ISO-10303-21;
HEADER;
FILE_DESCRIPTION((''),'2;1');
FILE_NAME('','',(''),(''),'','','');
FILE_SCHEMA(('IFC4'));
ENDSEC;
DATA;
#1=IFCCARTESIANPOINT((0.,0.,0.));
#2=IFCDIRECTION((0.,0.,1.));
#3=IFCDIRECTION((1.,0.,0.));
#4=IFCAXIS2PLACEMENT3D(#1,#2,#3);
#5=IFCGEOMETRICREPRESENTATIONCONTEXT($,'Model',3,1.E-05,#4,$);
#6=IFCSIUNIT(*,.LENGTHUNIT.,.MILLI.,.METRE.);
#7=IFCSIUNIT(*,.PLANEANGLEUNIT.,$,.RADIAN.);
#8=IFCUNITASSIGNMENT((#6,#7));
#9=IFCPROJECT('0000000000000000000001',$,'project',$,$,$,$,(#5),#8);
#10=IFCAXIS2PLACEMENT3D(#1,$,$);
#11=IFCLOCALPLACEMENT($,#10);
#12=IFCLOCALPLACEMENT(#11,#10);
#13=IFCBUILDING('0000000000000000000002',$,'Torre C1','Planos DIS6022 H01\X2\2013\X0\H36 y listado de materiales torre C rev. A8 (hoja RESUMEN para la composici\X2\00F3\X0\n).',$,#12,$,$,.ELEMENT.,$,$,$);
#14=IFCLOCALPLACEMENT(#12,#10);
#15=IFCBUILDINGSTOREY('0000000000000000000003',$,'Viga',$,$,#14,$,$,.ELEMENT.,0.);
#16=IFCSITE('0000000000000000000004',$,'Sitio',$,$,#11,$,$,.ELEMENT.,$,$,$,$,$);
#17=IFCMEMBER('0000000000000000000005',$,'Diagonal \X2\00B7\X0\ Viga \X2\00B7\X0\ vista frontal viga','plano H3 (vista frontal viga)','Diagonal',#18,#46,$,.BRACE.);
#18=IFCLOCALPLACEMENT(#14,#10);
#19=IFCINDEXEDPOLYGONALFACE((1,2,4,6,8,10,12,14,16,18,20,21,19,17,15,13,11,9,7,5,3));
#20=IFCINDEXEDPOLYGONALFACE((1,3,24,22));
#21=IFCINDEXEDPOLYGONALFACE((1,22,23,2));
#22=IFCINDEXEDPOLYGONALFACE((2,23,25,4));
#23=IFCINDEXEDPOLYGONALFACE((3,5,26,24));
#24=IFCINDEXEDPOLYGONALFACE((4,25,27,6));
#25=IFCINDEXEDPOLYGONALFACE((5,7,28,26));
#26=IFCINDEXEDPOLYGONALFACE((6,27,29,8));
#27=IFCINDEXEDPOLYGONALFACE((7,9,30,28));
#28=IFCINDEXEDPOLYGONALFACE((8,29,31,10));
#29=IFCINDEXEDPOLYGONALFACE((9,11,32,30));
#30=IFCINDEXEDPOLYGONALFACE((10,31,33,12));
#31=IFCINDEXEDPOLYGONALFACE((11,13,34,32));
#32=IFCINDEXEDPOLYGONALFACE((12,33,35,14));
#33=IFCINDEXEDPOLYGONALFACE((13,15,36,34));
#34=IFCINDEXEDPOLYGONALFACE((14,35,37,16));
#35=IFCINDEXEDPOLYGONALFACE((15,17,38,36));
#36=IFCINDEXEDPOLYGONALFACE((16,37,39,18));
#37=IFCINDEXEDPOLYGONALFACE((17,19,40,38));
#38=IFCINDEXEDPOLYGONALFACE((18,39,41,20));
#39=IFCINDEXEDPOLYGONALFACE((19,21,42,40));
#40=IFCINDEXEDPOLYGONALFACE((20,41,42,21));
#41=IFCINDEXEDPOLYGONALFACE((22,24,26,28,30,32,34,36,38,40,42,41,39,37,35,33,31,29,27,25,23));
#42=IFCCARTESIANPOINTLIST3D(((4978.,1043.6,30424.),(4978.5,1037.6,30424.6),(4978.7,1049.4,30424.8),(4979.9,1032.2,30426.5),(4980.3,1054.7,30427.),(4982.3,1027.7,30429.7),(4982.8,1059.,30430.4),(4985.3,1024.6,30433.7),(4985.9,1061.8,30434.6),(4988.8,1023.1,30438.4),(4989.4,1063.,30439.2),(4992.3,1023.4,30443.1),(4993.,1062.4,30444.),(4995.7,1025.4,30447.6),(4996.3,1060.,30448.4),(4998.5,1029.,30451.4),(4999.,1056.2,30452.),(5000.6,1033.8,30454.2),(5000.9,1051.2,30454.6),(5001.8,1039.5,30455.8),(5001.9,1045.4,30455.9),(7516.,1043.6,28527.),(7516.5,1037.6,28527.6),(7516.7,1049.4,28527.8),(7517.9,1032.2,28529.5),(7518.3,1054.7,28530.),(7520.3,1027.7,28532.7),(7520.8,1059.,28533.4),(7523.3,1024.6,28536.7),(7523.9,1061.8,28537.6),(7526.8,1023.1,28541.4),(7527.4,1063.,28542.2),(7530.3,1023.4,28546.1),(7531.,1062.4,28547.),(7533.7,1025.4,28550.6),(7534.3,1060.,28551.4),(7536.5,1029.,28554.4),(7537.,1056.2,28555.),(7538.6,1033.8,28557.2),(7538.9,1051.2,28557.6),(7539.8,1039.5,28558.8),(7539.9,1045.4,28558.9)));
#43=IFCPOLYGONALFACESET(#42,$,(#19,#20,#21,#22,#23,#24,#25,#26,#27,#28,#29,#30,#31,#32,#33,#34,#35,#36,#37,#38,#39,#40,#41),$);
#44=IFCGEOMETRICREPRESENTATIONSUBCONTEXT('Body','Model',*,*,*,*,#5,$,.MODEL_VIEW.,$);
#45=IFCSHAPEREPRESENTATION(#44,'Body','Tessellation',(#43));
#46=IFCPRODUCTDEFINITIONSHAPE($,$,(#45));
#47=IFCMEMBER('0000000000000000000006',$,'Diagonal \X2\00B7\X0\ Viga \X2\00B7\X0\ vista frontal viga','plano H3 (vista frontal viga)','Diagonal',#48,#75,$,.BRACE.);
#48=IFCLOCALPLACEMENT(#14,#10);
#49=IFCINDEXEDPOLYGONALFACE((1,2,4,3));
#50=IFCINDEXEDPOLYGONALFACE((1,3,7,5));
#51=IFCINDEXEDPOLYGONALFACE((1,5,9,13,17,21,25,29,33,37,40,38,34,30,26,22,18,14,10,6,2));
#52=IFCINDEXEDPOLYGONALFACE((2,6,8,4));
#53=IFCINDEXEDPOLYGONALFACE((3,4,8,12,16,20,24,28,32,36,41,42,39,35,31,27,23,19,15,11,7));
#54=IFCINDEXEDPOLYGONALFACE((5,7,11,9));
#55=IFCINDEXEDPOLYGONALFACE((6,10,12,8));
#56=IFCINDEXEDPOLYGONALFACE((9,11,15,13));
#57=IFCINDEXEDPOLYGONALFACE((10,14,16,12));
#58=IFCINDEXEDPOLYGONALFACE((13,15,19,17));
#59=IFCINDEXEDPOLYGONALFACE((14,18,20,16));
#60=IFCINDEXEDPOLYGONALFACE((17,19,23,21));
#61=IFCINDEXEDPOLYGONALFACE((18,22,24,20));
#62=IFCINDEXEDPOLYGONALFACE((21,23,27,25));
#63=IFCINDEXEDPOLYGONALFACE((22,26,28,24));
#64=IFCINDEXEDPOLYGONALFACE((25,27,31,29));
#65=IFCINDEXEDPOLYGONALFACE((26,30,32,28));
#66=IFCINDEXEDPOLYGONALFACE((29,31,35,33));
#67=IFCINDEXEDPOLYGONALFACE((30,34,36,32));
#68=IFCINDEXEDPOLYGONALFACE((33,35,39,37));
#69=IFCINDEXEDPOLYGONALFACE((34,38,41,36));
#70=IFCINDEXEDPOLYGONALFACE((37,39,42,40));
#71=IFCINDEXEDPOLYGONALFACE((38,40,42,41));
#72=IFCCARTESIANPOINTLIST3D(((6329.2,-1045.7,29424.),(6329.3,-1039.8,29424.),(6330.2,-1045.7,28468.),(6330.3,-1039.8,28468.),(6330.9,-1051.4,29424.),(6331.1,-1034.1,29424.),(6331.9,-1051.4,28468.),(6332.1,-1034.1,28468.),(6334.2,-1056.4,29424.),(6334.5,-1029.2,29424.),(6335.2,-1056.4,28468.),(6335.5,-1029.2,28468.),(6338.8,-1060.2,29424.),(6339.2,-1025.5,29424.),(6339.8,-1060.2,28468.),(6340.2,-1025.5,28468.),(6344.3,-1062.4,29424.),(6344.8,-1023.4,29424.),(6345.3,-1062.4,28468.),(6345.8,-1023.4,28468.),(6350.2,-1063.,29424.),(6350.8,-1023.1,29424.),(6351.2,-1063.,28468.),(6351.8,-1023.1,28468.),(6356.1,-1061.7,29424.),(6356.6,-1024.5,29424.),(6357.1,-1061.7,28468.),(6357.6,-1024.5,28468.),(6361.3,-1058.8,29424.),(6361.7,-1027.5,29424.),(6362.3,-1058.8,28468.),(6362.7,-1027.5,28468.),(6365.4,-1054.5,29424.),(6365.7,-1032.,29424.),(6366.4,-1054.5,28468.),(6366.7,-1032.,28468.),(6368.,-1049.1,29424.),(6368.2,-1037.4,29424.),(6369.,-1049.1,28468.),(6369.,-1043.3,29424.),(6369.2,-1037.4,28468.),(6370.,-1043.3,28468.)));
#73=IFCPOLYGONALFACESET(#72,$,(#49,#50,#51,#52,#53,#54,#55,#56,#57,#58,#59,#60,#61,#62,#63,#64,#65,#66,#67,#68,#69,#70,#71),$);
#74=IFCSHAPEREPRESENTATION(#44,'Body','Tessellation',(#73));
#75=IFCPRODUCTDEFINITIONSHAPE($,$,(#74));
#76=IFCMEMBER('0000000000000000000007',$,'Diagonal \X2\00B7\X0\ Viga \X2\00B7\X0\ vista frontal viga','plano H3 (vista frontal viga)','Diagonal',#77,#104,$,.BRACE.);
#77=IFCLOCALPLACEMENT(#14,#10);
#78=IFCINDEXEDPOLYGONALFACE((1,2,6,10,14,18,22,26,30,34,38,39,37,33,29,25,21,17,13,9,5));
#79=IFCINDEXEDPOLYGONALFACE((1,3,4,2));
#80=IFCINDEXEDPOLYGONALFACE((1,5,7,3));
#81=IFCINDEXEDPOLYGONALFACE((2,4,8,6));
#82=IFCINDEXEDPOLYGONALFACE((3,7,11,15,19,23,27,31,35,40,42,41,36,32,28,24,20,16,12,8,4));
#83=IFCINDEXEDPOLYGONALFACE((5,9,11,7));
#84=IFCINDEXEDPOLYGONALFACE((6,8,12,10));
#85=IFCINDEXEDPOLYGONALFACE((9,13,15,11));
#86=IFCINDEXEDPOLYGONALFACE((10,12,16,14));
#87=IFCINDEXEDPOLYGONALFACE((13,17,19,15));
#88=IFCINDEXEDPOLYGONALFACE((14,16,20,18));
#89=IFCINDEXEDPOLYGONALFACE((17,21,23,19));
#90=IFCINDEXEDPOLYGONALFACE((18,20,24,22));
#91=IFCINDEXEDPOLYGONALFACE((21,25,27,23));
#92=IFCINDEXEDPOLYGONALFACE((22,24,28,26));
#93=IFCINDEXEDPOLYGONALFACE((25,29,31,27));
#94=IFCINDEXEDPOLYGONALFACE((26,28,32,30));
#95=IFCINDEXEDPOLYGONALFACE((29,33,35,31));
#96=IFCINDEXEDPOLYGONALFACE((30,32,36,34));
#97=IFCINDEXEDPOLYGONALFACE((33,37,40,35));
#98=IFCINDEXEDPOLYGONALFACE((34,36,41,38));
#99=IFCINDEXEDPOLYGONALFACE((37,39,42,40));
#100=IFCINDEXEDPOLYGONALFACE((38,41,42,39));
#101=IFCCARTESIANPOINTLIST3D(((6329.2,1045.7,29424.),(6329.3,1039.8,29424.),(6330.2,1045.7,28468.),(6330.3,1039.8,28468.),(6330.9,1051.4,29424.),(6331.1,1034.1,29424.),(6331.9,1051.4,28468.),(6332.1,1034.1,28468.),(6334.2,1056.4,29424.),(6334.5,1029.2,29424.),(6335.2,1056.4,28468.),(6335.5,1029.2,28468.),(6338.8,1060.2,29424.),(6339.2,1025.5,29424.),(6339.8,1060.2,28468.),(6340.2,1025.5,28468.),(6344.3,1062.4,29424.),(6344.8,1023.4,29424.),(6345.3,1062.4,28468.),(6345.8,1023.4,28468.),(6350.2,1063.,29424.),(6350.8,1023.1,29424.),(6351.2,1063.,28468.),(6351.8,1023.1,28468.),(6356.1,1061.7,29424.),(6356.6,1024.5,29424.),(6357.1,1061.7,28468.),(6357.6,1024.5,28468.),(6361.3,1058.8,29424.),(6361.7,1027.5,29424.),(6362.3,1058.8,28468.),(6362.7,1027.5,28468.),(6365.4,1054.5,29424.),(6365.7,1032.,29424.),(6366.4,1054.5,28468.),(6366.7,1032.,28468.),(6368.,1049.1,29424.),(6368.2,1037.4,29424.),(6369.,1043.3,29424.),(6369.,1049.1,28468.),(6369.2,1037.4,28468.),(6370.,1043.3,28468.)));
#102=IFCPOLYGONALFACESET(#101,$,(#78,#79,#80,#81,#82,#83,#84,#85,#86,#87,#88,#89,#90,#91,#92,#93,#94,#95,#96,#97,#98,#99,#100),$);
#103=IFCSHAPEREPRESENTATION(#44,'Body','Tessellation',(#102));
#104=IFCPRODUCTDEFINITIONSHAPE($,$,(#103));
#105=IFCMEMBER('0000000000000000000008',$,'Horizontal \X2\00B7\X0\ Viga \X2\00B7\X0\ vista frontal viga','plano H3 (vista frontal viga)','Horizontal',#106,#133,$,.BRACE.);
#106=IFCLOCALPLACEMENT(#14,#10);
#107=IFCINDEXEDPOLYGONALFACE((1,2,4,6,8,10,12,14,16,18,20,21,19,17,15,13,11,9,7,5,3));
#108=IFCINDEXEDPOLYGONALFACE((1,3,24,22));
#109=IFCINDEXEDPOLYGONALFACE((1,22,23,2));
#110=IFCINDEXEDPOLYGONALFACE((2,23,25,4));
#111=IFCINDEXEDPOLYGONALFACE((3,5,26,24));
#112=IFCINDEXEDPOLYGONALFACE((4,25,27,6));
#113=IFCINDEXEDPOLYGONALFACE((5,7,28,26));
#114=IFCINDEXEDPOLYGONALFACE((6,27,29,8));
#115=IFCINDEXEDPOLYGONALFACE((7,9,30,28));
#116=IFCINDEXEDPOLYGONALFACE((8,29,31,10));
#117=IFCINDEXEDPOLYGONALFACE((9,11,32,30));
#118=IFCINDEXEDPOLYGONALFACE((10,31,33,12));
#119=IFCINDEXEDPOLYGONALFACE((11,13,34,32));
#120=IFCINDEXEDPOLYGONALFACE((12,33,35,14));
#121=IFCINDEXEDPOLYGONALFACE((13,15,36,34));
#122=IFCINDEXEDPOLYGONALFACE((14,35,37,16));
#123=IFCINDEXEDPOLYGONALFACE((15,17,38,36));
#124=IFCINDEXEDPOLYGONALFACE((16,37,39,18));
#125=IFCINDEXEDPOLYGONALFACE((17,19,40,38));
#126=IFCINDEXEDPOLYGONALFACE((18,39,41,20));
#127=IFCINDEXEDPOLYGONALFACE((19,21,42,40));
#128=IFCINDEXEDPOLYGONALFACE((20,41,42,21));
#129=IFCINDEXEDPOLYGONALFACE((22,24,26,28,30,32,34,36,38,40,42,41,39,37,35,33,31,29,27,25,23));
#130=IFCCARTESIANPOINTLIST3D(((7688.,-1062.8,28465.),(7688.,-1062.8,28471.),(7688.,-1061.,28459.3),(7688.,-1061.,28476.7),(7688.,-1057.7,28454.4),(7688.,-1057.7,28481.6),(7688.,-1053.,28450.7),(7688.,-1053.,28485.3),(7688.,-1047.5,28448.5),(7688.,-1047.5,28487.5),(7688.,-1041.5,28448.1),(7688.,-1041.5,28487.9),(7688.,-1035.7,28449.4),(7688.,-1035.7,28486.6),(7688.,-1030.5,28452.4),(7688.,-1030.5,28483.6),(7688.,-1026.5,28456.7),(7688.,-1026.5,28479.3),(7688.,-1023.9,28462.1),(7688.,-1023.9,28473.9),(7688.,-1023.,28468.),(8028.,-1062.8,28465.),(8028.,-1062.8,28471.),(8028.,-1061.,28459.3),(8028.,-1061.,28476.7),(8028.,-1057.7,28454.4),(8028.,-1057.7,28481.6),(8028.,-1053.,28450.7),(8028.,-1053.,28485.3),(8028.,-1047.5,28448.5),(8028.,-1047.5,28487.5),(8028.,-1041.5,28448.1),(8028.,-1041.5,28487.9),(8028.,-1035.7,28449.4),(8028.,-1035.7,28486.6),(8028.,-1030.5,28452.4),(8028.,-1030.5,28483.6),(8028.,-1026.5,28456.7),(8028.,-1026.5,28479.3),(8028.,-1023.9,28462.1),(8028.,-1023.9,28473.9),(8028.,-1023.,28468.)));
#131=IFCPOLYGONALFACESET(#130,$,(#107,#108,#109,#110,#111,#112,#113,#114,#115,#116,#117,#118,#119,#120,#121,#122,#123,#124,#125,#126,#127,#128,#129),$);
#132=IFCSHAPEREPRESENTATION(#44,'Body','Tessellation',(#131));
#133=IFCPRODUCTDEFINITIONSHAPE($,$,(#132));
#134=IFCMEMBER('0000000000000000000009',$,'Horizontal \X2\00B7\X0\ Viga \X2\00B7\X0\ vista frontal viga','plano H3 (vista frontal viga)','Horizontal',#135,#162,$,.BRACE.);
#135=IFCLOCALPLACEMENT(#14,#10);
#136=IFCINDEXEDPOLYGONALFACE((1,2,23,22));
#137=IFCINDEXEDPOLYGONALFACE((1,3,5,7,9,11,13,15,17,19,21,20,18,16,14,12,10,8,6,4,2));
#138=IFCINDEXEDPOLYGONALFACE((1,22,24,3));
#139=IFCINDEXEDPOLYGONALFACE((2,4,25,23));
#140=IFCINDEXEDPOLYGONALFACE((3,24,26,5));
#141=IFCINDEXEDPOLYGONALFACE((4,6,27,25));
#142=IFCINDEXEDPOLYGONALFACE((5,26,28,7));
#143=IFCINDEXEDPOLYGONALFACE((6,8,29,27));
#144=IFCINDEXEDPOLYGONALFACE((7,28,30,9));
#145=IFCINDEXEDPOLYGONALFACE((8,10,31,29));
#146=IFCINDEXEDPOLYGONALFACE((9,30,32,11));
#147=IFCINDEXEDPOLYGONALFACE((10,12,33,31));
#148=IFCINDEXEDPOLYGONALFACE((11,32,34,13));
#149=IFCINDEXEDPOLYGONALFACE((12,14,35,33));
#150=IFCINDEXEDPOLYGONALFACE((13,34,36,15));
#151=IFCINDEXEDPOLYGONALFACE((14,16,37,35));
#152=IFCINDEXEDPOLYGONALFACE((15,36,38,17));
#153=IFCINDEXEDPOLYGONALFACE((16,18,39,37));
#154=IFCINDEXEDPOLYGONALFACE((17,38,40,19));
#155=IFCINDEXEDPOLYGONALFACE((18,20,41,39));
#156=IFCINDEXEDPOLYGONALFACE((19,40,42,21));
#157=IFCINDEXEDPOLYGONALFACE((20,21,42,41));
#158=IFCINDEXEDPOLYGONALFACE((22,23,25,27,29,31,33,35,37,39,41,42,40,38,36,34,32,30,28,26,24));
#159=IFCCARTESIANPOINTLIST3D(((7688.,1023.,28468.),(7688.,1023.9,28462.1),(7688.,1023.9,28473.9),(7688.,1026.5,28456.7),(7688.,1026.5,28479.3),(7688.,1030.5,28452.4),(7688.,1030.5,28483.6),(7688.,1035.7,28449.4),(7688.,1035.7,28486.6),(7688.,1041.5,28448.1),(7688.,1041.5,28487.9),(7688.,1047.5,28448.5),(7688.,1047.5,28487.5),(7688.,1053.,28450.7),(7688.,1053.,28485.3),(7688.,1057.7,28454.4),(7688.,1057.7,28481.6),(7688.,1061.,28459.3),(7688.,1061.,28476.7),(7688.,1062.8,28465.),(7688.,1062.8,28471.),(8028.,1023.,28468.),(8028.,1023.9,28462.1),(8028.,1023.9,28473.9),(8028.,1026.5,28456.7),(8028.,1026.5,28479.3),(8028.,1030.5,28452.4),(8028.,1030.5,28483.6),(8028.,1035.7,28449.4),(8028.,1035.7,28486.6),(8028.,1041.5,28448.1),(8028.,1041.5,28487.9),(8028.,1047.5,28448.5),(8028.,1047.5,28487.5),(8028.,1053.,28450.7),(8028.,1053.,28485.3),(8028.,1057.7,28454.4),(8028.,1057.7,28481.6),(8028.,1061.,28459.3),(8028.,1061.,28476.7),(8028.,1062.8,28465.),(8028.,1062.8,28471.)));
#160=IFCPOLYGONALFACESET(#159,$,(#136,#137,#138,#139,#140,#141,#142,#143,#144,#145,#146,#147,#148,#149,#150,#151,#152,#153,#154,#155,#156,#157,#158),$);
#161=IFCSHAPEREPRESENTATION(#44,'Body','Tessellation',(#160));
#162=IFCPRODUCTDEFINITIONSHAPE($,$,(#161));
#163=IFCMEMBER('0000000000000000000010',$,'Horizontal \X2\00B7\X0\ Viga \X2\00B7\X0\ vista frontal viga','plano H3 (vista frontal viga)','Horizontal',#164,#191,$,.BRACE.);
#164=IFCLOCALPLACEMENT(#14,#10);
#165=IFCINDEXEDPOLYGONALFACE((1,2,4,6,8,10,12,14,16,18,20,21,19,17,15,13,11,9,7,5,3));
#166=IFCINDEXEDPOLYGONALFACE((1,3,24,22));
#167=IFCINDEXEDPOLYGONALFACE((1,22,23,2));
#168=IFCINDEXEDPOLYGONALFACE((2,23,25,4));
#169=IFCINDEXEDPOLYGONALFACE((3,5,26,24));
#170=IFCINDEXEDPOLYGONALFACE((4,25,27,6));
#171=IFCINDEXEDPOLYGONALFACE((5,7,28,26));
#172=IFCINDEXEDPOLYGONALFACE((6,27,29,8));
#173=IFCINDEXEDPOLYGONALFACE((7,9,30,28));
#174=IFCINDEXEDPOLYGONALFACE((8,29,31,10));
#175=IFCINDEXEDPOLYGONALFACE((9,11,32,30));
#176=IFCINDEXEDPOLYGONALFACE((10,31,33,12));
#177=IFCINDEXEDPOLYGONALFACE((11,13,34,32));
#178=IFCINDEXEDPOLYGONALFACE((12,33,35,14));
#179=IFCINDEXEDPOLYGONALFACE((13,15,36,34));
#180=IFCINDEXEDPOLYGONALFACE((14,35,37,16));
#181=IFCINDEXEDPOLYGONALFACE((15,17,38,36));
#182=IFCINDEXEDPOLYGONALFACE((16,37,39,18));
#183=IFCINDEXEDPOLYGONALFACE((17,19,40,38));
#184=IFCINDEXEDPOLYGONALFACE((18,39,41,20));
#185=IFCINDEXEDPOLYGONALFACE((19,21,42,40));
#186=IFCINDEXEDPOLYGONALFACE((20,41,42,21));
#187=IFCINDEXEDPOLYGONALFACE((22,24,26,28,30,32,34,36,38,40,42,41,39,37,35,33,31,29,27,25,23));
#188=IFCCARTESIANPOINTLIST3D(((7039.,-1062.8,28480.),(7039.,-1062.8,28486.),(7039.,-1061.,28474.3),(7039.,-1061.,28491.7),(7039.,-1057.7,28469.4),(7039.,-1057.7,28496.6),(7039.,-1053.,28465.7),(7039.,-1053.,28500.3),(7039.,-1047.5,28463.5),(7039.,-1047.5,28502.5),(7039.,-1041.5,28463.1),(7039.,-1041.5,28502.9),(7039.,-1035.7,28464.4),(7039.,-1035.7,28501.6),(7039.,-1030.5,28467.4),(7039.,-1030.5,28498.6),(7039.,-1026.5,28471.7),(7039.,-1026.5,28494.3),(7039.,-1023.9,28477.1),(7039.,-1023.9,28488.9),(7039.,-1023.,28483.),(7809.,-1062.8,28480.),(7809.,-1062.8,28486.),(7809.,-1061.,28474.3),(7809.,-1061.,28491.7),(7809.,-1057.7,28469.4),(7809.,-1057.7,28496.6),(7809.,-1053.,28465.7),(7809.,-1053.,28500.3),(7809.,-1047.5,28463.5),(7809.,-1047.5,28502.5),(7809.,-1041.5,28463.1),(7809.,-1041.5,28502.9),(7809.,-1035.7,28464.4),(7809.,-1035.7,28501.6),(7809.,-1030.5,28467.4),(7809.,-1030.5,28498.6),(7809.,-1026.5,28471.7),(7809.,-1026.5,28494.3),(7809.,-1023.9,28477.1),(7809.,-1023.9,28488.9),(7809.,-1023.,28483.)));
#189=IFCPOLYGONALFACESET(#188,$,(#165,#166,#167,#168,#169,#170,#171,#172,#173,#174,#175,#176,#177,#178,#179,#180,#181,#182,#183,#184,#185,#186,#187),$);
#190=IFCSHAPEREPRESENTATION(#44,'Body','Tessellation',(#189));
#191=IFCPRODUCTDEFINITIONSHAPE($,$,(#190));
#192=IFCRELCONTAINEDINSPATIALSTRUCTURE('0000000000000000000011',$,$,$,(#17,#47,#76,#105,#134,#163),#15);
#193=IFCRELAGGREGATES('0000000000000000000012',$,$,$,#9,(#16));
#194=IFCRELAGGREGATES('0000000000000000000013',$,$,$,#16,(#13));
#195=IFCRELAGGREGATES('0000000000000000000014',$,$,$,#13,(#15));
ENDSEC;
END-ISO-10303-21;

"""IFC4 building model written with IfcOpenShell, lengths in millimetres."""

from ifc_helpers import new_model, si_unit, frame, origin, origin_with_axes, place, context, subcontext, project, spatial, circle, extrude, element, save


model = new_model("IFC4")

# Units and contexts
model_context = context("Model", 3, precision=1e-05, world=origin_with_axes())
body_context = subcontext(model_context, "Body", "Model", "MODEL_VIEW")
ifc_project = project(units=[si_unit("LENGTHUNIT", "METRE", prefix="MILLI"), si_unit("PLANEANGLEUNIT", "RADIAN")], contexts=[model_context])

# Site, building, storey
site_placement = place(None, origin())
site = spatial("IfcSite", under=ifc_project, at=site_placement, Name="Sitio", CompositionType="ELEMENT")
building_placement = place(site_placement, origin())
building = spatial("IfcBuilding", under=site, at=building_placement, Name="Torre C1", Description="Planos DIS6022 H01–H36 y listado de materiales torre C rev. A8 (hoja RESUMEN para la composición).", CompositionType="ELEMENT")
storey_placement = place(building_placement, origin())
storey = spatial("IfcBuildingStorey", under=building, at=storey_placement, Name="Viga", CompositionType="ELEMENT", Elevation=0.0)

# Members
for number, where, z_axis, x_axis, name in (
    (1, (7528.0, 1043.0, 28543.0), (-0.800984, 0.0, 0.598686), (-0.576761, -0.268149, -0.771649), "Diagonal · Viga · vista frontal viga"),
):
    element("IfcMember", number, at=place(storey_placement, frame(where, z_axis=z_axis, x_axis=x_axis)), inside=storey, Name=name, Description="plano H3 (vista frontal viga)", ObjectType="Diagonal", PredefinedType="BRACE", context=body_context, shape_type="SweptSolid", body=[
        extrude(circle(Radius=20.0), None, (0.0, 0.0, 1.0), 3168.6),
    ])
for number, where, z_axis, x_axis, name in (
    (2, (6349.0, -1043.0, 29424.0), (0.001046, 0.0, -0.999999), (-0.986775, 0.162093, -0.001032), "Diagonal · Viga · vista frontal viga"),
    (3, (6349.0, 1043.0, 29424.0), (0.001046, 0.0, -0.999999), (-0.986775, -0.162093, -0.001032), "Diagonal · Viga · vista frontal viga"),
):
    element("IfcMember", number, at=place(storey_placement, frame(where, z_axis=z_axis, x_axis=x_axis)), inside=storey, Name=name, Description="plano H3 (vista frontal viga)", ObjectType="Diagonal", PredefinedType="BRACE", context=body_context, shape_type="SweptSolid", body=[
        extrude(circle(Radius=20.0), None, (0.0, 0.0, 1.0), 956.0),
    ])
for number, where, z_axis, x_axis, name in (
    (4, (7688.0, -1043.0, 28468.0), (1.0, 0.0, 0.0), (0.0, 1.0, 0.0), "Horizontal · Viga · vista frontal viga"),
    (5, (7688.0, 1043.0, 28468.0), (1.0, 0.0, 0.0), (0.0, -1.0, 0.0), "Horizontal · Viga · vista frontal viga"),
):
    element("IfcMember", number, at=place(storey_placement, frame(where, z_axis=z_axis, x_axis=x_axis)), inside=storey, Name=name, Description="plano H3 (vista frontal viga)", ObjectType="Horizontal", PredefinedType="BRACE", context=body_context, shape_type="SweptSolid", body=[
        extrude(circle(Radius=20.0), None, (0.0, 0.0, 1.0), 340.0),
    ])
for number, where, z_axis, x_axis, name in (
    (6, (7809.0, -1043.0, 28483.0), (-1.0, 0.0, 0.0), (0.0, 1.0, 0.0), "Horizontal · Viga · vista frontal viga"),
):
    element("IfcMember", number, at=place(storey_placement, frame(where, z_axis=z_axis, x_axis=x_axis)), inside=storey, Name=name, Description="plano H3 (vista frontal viga)", ObjectType="Horizontal", PredefinedType="BRACE", context=body_context, shape_type="SweptSolid", body=[
        extrude(circle(Radius=20.0), None, (0.0, 0.0, 1.0), 770.0),
    ])

save(model, "model.ifc")
